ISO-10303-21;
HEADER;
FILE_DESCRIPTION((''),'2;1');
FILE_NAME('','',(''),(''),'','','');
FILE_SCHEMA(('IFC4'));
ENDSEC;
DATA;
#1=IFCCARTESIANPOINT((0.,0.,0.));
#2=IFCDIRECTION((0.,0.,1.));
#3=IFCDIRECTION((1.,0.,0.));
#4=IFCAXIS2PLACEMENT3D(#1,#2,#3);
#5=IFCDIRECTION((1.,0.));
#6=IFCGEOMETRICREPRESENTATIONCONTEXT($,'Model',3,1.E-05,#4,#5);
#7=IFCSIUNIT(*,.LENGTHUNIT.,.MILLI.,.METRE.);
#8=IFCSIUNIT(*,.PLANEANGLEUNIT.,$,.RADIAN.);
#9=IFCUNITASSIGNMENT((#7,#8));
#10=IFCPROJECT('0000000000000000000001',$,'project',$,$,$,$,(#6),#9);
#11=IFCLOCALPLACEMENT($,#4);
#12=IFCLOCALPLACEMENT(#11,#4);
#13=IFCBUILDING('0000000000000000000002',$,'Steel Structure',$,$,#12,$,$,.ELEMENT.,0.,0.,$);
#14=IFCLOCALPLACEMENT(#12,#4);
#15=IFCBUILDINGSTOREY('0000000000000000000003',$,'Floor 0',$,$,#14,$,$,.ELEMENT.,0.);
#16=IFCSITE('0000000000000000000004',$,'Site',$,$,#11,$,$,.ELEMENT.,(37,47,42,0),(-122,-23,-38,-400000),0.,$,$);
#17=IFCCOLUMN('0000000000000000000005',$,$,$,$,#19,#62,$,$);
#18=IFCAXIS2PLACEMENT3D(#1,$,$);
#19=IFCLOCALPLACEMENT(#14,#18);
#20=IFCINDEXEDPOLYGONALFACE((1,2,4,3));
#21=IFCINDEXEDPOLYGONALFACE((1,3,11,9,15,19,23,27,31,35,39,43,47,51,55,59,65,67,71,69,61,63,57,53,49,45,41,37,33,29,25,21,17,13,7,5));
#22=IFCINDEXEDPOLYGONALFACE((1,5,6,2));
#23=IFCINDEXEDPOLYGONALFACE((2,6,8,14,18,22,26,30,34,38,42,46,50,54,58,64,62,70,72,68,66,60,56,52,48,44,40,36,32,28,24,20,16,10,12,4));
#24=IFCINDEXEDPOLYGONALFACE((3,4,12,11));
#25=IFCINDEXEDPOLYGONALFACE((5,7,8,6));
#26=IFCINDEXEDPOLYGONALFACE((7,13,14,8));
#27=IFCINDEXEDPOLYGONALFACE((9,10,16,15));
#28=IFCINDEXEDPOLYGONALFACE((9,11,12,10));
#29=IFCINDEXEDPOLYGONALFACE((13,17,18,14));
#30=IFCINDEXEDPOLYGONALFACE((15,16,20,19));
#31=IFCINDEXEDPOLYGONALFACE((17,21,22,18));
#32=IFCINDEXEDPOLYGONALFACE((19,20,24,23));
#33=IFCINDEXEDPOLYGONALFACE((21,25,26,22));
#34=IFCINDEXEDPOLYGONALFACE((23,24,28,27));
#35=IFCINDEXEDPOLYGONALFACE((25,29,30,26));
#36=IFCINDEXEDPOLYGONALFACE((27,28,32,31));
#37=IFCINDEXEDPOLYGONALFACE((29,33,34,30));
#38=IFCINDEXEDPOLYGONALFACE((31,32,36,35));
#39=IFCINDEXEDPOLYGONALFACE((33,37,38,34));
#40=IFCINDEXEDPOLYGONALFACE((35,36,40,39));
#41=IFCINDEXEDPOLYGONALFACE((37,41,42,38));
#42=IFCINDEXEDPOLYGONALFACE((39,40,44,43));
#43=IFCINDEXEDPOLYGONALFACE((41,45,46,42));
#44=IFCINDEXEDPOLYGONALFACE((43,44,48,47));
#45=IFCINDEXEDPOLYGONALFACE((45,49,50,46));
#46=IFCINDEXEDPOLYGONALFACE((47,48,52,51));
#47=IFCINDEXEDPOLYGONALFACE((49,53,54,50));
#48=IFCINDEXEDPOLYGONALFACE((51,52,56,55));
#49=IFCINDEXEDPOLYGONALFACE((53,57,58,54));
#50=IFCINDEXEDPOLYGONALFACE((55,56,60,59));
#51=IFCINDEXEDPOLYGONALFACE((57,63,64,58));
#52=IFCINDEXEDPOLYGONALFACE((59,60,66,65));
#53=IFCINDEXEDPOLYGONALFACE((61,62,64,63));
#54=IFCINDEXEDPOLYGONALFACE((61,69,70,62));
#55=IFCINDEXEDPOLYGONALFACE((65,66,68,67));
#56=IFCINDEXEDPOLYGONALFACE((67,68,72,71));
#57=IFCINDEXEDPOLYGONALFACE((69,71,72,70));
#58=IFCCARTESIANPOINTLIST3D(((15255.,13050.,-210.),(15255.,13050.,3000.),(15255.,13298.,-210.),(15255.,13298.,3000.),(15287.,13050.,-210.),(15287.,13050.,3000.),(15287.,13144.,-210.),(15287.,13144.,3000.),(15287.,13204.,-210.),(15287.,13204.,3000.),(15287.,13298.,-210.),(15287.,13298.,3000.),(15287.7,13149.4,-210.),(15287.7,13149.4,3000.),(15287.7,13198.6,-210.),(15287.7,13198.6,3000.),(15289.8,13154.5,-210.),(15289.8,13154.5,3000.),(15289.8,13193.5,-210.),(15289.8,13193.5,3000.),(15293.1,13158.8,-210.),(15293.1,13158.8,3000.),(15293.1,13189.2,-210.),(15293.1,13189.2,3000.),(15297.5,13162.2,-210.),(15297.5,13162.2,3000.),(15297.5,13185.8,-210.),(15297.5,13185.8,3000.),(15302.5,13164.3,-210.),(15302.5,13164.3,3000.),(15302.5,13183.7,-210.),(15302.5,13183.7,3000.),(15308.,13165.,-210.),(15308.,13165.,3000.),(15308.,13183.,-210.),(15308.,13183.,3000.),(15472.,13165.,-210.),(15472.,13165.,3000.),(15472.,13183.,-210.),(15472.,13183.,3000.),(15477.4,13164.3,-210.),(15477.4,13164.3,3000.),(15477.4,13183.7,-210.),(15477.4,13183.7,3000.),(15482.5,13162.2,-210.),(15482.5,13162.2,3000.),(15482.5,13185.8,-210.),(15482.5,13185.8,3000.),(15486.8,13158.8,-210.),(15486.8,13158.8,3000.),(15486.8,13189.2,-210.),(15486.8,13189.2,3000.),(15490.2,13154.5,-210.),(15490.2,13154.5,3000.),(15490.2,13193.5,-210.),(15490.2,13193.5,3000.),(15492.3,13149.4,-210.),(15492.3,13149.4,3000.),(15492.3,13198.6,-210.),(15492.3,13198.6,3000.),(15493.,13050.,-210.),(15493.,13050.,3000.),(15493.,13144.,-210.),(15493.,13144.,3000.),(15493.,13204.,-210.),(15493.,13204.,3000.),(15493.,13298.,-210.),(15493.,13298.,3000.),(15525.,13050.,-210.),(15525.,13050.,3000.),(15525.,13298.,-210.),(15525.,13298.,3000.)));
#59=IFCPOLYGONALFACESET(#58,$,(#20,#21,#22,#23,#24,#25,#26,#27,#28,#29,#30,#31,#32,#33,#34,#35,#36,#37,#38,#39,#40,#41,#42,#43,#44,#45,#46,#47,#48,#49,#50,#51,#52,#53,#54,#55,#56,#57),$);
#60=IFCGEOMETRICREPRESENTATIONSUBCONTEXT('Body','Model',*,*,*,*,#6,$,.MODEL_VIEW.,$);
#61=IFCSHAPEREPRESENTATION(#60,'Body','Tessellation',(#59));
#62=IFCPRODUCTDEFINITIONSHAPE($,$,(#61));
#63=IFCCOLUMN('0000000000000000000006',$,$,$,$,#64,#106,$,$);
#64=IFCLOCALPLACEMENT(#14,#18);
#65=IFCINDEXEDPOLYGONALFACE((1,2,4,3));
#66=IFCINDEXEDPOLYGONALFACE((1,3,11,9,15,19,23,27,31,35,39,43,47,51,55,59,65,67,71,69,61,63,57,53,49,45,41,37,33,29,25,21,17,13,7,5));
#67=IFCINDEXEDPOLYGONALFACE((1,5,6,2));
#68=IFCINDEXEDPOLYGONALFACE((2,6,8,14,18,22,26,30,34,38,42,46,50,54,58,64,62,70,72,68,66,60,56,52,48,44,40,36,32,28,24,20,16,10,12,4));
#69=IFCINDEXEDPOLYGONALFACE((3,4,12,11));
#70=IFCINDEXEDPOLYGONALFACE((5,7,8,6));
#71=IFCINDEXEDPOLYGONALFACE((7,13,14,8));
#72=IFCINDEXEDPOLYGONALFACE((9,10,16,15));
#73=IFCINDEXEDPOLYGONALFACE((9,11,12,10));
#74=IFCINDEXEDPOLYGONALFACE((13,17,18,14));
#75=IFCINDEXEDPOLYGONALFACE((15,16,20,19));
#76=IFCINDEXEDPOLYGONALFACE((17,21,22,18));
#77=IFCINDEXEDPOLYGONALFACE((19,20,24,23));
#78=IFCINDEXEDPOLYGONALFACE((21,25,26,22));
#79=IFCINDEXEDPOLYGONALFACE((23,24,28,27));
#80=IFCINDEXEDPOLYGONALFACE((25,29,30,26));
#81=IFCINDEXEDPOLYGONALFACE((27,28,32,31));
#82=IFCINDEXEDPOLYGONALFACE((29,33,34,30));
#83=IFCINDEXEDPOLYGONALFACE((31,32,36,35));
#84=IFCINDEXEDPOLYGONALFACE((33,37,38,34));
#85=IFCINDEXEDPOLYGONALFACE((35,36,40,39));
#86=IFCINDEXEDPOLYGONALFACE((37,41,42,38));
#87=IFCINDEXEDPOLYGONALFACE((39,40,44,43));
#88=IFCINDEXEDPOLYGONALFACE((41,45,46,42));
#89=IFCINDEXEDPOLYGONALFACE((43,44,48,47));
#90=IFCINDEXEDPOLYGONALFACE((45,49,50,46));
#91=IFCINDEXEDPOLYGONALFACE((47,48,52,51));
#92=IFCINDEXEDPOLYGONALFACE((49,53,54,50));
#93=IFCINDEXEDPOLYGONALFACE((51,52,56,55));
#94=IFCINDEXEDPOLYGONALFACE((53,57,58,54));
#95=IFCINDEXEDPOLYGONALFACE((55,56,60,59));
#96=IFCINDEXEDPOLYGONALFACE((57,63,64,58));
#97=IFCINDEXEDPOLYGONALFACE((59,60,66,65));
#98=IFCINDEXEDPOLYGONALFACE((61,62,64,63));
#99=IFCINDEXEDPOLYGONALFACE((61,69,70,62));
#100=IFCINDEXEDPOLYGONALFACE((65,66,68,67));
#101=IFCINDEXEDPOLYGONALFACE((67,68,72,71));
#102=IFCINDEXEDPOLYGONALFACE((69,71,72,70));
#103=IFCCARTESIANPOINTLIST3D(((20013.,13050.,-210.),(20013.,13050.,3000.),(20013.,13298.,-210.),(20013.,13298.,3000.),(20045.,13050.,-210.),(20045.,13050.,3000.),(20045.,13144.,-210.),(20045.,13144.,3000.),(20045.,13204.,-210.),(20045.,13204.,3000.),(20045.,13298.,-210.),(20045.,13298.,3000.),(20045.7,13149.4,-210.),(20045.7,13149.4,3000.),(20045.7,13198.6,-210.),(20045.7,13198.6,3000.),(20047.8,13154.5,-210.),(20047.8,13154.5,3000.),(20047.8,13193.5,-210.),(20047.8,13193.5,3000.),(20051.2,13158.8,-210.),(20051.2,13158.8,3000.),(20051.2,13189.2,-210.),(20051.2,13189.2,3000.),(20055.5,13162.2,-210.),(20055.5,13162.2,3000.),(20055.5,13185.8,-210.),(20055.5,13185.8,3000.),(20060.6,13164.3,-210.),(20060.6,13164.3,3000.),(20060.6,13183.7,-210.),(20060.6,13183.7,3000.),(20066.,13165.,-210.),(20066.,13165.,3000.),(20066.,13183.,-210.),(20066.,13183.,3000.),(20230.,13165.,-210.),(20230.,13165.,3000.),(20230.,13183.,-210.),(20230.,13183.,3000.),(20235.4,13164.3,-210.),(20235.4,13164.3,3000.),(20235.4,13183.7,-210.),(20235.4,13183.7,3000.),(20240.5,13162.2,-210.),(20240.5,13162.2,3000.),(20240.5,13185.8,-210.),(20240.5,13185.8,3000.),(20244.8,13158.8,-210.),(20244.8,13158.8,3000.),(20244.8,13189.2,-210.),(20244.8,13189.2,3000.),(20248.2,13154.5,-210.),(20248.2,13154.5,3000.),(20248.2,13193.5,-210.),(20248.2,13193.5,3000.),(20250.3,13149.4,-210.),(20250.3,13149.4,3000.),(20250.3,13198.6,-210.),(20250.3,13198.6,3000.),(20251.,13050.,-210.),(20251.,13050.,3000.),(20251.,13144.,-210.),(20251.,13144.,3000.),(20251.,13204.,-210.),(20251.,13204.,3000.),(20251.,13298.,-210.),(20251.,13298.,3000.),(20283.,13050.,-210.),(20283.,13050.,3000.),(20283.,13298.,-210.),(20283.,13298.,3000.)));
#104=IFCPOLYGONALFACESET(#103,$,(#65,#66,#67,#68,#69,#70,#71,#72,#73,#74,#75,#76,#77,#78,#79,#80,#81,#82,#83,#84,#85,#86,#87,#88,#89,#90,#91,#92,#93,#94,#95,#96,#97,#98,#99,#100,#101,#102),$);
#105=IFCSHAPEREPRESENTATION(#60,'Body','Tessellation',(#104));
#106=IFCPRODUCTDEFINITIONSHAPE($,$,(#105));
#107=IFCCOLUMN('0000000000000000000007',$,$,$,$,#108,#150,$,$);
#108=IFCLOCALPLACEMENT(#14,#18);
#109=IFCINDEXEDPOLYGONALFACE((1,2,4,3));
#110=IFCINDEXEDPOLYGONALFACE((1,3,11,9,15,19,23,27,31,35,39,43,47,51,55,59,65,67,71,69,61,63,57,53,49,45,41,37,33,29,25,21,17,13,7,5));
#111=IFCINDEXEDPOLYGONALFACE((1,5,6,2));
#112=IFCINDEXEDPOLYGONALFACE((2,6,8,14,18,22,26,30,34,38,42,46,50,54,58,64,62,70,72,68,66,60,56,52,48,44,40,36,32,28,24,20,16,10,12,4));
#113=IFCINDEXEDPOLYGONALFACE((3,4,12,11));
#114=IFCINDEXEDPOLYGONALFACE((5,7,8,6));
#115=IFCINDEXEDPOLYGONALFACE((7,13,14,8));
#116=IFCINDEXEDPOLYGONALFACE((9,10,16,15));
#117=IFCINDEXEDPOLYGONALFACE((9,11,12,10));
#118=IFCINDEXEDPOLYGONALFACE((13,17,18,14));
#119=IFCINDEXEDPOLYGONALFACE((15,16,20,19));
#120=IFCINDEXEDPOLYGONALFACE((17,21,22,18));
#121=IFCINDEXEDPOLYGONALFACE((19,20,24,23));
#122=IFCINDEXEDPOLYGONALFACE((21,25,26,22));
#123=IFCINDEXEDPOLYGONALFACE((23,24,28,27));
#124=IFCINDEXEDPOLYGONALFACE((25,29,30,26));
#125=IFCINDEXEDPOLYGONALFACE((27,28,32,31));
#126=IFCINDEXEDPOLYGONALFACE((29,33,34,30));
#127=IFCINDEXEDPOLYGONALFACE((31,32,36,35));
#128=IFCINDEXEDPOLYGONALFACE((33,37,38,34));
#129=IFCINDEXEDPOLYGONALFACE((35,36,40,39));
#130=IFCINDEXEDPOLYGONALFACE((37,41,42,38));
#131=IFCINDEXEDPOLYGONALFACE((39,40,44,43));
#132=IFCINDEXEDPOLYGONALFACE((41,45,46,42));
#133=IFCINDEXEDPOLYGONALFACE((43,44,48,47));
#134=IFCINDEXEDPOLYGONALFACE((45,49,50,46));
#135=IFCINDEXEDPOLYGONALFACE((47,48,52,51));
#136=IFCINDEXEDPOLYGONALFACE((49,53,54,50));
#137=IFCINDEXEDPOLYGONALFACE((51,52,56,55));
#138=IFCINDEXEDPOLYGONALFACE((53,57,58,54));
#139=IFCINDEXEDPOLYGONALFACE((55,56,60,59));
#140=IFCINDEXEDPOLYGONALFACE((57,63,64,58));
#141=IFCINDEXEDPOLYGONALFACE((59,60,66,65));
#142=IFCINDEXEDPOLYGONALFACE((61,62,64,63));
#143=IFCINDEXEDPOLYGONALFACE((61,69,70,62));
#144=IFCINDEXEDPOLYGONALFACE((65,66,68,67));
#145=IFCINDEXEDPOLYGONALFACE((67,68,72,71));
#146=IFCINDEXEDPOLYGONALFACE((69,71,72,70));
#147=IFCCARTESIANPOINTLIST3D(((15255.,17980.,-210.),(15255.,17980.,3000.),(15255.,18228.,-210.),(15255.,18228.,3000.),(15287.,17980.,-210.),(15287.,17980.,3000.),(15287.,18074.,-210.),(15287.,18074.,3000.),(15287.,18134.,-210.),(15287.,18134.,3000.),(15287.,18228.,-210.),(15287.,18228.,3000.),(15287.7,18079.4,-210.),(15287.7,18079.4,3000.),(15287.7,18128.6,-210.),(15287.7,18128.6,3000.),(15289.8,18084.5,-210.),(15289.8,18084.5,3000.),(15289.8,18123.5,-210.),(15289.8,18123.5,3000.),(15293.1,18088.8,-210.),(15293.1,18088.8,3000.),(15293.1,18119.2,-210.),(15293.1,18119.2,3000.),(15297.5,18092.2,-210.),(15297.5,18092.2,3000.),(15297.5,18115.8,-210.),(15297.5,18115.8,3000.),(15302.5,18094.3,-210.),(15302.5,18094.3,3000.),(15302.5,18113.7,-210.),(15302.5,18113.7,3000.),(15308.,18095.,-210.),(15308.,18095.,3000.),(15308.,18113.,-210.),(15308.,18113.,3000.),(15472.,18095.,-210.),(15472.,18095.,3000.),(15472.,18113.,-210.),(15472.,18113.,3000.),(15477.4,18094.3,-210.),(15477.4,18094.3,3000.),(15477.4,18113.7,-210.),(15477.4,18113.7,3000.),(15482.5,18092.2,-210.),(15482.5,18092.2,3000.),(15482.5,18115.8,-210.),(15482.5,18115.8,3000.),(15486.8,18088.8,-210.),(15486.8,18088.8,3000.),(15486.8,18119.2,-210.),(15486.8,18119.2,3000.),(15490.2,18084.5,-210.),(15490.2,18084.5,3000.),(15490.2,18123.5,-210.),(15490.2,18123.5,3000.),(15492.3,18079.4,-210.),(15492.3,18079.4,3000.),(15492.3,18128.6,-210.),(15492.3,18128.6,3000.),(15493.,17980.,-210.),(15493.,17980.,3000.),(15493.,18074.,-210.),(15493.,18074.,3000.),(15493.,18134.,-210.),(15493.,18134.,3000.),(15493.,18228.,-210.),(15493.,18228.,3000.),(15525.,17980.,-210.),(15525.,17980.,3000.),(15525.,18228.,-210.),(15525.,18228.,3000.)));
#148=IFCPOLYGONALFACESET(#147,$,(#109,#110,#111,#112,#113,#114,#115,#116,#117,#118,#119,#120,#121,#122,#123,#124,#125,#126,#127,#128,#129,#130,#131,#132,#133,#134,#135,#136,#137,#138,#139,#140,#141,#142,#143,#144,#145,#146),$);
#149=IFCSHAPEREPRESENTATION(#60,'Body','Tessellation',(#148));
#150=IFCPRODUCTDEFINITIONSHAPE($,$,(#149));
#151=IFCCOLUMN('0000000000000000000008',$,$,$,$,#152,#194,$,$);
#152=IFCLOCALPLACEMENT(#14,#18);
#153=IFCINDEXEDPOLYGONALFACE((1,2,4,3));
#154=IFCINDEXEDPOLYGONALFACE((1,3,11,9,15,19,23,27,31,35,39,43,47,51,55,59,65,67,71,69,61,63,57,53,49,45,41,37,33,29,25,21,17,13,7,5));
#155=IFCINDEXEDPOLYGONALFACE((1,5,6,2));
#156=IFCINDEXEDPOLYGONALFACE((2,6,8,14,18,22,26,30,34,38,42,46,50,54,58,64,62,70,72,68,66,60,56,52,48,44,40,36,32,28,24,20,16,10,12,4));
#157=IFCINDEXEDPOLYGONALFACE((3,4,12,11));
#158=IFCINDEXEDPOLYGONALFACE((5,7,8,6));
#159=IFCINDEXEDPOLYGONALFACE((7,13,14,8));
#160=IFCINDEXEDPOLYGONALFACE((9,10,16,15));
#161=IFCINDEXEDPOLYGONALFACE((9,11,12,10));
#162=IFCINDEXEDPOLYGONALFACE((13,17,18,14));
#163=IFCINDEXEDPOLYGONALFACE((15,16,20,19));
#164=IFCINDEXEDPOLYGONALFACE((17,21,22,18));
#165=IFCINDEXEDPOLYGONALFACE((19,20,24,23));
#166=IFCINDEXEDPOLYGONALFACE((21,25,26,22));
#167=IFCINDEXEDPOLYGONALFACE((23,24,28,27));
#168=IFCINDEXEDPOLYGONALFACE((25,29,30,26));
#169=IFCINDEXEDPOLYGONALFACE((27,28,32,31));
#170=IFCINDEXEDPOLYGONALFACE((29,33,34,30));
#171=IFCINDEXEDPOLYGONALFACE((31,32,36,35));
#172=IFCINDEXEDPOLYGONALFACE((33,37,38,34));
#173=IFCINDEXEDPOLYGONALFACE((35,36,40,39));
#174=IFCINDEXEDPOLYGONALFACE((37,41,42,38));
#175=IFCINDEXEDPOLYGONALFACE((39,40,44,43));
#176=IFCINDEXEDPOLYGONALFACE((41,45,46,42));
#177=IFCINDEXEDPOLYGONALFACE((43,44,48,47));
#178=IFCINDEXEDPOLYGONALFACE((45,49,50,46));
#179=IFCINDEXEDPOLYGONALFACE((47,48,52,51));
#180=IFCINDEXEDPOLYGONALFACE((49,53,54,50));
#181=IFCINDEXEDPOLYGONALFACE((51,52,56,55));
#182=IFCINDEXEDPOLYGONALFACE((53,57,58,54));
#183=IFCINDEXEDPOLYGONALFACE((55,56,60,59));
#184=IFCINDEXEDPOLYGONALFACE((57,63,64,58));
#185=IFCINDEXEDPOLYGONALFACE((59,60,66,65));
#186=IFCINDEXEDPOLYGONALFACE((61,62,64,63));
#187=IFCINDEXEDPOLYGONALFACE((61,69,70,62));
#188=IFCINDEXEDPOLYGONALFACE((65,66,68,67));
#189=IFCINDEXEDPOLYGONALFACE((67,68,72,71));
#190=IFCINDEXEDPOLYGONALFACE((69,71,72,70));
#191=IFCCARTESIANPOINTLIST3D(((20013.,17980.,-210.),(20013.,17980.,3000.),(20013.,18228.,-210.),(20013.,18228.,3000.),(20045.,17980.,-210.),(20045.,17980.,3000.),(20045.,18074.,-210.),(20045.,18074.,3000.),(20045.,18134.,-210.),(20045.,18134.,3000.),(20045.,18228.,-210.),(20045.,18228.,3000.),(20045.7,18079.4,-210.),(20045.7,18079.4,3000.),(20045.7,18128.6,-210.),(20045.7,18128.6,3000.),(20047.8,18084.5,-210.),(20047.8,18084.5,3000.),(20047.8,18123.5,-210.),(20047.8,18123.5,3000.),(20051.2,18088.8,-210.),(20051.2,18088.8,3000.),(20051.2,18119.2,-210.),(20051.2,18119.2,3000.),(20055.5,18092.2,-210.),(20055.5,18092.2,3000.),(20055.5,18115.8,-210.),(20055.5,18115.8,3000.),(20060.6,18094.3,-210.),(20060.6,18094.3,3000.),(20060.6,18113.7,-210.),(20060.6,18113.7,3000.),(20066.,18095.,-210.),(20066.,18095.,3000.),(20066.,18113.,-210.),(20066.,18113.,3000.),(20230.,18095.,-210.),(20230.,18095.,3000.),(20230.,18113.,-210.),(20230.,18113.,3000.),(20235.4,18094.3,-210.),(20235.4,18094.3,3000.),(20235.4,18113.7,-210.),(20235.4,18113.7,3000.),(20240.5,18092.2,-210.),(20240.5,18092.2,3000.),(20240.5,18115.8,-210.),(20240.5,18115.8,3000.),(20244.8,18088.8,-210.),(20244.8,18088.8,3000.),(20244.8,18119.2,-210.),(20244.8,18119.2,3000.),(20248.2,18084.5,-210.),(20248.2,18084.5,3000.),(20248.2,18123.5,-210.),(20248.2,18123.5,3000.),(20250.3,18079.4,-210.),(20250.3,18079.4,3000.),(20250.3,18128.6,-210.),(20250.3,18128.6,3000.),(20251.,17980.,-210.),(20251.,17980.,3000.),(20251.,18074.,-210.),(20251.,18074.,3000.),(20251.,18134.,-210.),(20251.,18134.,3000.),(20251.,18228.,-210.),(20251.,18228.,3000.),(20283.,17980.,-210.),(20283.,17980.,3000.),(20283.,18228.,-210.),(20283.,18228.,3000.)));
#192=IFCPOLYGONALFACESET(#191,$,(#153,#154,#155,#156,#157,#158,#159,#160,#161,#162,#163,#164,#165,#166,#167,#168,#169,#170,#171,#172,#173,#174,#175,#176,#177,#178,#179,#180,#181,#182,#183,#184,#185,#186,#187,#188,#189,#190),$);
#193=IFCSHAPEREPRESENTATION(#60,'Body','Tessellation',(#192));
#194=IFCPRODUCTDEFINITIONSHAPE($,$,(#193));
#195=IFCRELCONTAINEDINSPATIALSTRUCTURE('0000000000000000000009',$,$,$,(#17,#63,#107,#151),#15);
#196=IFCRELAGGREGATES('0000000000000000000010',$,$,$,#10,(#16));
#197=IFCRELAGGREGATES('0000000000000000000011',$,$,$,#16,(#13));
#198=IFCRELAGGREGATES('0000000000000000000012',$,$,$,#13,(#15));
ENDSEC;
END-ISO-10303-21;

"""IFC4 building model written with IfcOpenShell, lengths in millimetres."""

from ifc_helpers import new_model, si_unit, direction, frame, origin_with_axes, origin_2d_with_axis, place, context, subcontext, project, spatial, i_section, extrude, element, save


model = new_model("IFC4")

# Units and contexts
model_context = context("Model", 3, precision=1e-05, world=origin_with_axes(), true_north=direction((1.0, 0.0)))
body_context = subcontext(model_context, "Body", "Model", "MODEL_VIEW")
ifc_project = project(units=[si_unit("LENGTHUNIT", "METRE", prefix="MILLI"), si_unit("PLANEANGLEUNIT", "RADIAN")], contexts=[model_context])

# Site, building, storey
site_placement = place(None, origin_with_axes())
site = spatial("IfcSite", under=ifc_project, at=site_placement, Name="Site", CompositionType="ELEMENT", RefLatitude=(37, 47, 42, 0), RefLongitude=(-122, -23, -38, -400000), RefElevation=0.0)
building_placement = place(site_placement, origin_with_axes())
building = spatial("IfcBuilding", under=site, at=building_placement, Name="Steel Structure", CompositionType="ELEMENT", ElevationOfRefHeight=0.0, ElevationOfTerrain=0.0)
storey_placement = place(building_placement, origin_with_axes())
storey = spatial("IfcBuildingStorey", under=building, at=storey_placement, Name="Floor 0", CompositionType="ELEMENT", Elevation=0.0)

# Columns
column_1_placement = place(storey_placement, frame((15390.0, 13174.0, -210.0), z_axis=(0.0, 0.0, 1.0), x_axis=(0.0, -1.0, 0.0)))
element("IfcColumn", 1, at=column_1_placement, inside=storey, context=body_context, shape_type="SweptSolid", body=[
    extrude(i_section(OverallWidth=248.0, OverallDepth=270.0, WebThickness=18.0, FlangeThickness=32.0, FilletRadius=21.0, at=origin_2d_with_axis()), origin_with_axes(), (0.0, 0.0, 1.0), 3210.0),
])
column_2_placement = place(storey_placement, frame((20148.0, 13174.0, -210.0), z_axis=(0.0, 0.0, 1.0), x_axis=(0.0, -1.0, 0.0)))
element("IfcColumn", 2, at=column_2_placement, inside=storey, context=body_context, shape_type="SweptSolid", body=[
    extrude(i_section(OverallWidth=248.0, OverallDepth=270.0, WebThickness=18.0, FlangeThickness=32.0, FilletRadius=21.0, at=origin_2d_with_axis()), origin_with_axes(), (0.0, 0.0, 1.0), 3210.0),
])
column_3_placement = place(storey_placement, frame((15390.0, 18104.0, -210.0), z_axis=(0.0, 0.0, 1.0), x_axis=(0.0, -1.0, 0.0)))
element("IfcColumn", 3, at=column_3_placement, inside=storey, context=body_context, shape_type="SweptSolid", body=[
    extrude(i_section(OverallWidth=248.0, OverallDepth=270.0, WebThickness=18.0, FlangeThickness=32.0, FilletRadius=21.0, at=origin_2d_with_axis()), origin_with_axes(), (0.0, 0.0, 1.0), 3210.0),
])
column_4_placement = place(storey_placement, frame((20148.0, 18104.0, -210.0), z_axis=(0.0, 0.0, 1.0), x_axis=(0.0, -1.0, 0.0)))
element("IfcColumn", 4, at=column_4_placement, inside=storey, context=body_context, shape_type="SweptSolid", body=[
    extrude(i_section(OverallWidth=248.0, OverallDepth=270.0, WebThickness=18.0, FlangeThickness=32.0, FilletRadius=21.0, at=origin_2d_with_axis()), origin_with_axes(), (0.0, 0.0, 1.0), 3210.0),
])

save(model, "model.ifc")
